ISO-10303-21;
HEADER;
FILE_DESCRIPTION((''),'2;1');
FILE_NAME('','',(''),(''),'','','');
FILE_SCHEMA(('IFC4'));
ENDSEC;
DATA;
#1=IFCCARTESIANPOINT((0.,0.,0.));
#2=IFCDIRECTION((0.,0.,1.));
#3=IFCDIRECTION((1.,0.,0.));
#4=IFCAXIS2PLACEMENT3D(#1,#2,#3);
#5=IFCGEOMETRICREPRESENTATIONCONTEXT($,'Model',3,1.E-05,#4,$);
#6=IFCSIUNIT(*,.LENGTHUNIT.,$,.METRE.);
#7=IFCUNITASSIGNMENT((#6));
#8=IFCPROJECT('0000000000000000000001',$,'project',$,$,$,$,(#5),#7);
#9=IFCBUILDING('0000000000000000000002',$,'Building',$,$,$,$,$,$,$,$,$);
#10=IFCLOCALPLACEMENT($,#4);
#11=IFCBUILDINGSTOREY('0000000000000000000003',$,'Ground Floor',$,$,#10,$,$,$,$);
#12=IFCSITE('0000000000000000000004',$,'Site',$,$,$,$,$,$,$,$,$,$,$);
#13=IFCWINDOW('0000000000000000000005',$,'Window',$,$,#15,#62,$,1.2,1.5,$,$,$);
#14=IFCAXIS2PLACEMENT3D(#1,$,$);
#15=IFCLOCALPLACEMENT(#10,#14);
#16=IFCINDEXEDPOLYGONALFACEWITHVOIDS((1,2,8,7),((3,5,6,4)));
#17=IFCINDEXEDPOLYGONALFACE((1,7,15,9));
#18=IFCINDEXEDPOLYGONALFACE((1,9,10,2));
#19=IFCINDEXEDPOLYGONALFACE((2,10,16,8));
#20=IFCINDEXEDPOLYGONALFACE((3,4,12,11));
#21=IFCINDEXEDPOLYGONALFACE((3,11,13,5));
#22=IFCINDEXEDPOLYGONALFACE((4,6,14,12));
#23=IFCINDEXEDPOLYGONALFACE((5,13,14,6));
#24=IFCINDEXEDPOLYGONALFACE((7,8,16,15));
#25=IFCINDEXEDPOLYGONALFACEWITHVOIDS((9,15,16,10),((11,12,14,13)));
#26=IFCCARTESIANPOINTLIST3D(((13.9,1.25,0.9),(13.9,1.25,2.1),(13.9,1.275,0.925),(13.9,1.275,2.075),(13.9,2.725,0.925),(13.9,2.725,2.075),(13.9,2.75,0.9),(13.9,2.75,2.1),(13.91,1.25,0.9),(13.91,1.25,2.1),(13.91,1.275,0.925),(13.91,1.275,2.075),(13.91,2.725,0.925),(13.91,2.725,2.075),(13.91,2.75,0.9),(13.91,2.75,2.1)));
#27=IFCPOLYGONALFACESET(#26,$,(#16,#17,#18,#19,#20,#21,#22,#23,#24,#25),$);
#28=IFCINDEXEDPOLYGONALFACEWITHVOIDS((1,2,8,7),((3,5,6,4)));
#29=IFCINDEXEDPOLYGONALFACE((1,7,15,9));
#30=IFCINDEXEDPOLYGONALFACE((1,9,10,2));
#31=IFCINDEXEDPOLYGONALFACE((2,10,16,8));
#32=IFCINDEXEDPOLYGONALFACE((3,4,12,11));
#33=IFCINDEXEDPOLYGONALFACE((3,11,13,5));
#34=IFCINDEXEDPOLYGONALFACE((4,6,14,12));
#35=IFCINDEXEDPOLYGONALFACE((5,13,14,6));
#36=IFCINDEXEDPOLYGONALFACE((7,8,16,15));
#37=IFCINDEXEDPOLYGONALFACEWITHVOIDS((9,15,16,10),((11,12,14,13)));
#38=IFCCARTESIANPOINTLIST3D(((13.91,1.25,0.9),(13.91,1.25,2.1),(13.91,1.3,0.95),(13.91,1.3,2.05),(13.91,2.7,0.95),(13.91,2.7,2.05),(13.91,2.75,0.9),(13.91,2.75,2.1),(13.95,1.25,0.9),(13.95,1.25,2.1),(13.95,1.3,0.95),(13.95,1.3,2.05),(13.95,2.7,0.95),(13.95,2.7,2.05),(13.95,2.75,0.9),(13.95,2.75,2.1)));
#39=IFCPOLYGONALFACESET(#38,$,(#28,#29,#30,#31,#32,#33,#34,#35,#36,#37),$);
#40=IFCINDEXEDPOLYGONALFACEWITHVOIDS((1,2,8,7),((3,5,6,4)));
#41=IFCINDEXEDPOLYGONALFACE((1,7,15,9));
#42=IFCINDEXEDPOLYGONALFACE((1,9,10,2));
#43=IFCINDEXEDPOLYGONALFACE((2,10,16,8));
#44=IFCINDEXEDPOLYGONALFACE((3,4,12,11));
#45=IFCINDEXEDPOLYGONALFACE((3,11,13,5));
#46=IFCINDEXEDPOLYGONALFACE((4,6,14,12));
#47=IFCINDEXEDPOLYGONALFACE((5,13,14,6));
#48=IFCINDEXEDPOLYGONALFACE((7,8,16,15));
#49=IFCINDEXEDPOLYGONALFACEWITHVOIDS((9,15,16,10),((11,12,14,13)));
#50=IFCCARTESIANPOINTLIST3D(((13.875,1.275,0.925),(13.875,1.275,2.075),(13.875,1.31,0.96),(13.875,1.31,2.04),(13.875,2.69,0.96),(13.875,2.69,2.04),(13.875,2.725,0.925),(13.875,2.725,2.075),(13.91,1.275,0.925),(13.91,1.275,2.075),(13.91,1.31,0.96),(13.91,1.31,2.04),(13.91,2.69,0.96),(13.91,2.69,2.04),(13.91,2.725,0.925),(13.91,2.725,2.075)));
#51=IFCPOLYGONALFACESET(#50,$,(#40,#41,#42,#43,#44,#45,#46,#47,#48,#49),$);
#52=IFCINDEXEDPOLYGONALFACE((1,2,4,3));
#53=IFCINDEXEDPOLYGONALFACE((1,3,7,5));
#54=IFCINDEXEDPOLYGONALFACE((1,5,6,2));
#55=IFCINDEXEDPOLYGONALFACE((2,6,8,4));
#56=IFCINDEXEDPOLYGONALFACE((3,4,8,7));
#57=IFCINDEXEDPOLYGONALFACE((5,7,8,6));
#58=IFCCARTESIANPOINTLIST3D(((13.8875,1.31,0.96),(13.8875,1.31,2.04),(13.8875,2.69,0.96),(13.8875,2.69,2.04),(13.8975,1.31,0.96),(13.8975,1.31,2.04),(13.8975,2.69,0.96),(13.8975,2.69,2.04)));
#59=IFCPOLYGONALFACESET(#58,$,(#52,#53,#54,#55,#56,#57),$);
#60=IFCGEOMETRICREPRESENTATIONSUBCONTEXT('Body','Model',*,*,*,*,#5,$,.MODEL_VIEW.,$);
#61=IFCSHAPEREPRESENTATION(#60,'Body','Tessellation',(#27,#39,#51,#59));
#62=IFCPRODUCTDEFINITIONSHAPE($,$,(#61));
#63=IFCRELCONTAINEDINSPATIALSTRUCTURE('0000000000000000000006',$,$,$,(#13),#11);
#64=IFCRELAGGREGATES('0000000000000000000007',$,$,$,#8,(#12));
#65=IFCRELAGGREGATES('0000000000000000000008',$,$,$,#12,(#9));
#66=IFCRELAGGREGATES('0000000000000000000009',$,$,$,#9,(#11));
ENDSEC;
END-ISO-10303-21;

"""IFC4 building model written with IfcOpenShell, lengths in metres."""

from ifc_helpers import new_model, si_unit, frame, origin_with_axes, place, context, subcontext, project, spatial, line, indexed_curve, outline, extrude, element, save


model = new_model("IFC4")

# Units and contexts
model_context = context("Model", 3, precision=1e-05, world=origin_with_axes())
body_context = subcontext(model_context, "Body", "Model", "MODEL_VIEW")
ifc_project = project(units=[si_unit("LENGTHUNIT", "METRE")], contexts=[model_context])

# Site, building, storey
site = spatial("IfcSite", under=ifc_project, Name="Site")
building = spatial("IfcBuilding", under=site, Name="Building")
storey_placement = place(None, origin_with_axes())
storey = spatial("IfcBuildingStorey", under=building, at=storey_placement, Name="Ground Floor")

# Window
window_placement = place(storey_placement, frame((14.0, 1.25, 0.9), z_axis=(0.0, 0.0, 1.0), x_axis=(0.0, 1.0, 0.0)))
element("IfcWindow", 1, at=window_placement, inside=storey, Name="Window", OverallHeight=1.2, OverallWidth=1.5, context=body_context, shape_type="SweptSolid", body=[
    extrude(outline(indexed_curve([(0.0, 0.0), (1.5, 0.0), (1.5, 1.2), (0.0, 1.2)], segments=[line(1, 2, 3, 4, 1)]), holes=[indexed_curve([(0.025, 0.025), (1.475, 0.025), (1.475, 1.175), (0.025, 1.175)], segments=[line(1, 2, 3, 4, 1)])]), frame((0.0, 0.09, 0.0), z_axis=(0.0, -1.0, 0.0), x_axis=(1.0, 0.0, 0.0)), (0.0, 0.0, -1.0), 0.01),
    extrude(outline(indexed_curve([(0.0, 0.0), (1.5, 0.0), (1.5, 1.2), (0.0, 1.2)], segments=[line(1, 2, 3, 4, 1)]), holes=[indexed_curve([(0.05, 0.05), (1.45, 0.05), (1.45, 1.15), (0.05, 1.15)], segments=[line(1, 2, 3, 4, 1)])]), frame((0.0, 0.05, 0.0), z_axis=(0.0, -1.0, 0.0), x_axis=(1.0, 0.0, 0.0)), (0.0, 0.0, -1.0), 0.04),
    extrude(outline(indexed_curve([(0.0, 0.0), (1.45, 0.0), (1.45, 1.15), (0.0, 1.15)], segments=[line(1, 2, 3, 4, 1)]), holes=[indexed_curve([(0.035, 0.035), (1.415, 0.035), (1.415, 1.115), (0.035, 1.115)], segments=[line(1, 2, 3, 4, 1)])]), frame((0.025, 0.09, 0.025), z_axis=(0.0, -1.0, 0.0), x_axis=(1.0, 0.0, 0.0)), (0.0, 0.0, -1.0), 0.035),
    extrude(outline(indexed_curve([(0.035, 0.035), (1.415, 0.035), (1.415, 1.115), (0.035, 1.115)], segments=[line(1, 2, 3, 4, 1)])), frame((0.025, 0.1025, 0.025), z_axis=(0.0, -1.0, 0.0), x_axis=(1.0, 0.0, 0.0)), (0.0, 0.0, -1.0), 0.01),
])

save(model, "model.ifc")
